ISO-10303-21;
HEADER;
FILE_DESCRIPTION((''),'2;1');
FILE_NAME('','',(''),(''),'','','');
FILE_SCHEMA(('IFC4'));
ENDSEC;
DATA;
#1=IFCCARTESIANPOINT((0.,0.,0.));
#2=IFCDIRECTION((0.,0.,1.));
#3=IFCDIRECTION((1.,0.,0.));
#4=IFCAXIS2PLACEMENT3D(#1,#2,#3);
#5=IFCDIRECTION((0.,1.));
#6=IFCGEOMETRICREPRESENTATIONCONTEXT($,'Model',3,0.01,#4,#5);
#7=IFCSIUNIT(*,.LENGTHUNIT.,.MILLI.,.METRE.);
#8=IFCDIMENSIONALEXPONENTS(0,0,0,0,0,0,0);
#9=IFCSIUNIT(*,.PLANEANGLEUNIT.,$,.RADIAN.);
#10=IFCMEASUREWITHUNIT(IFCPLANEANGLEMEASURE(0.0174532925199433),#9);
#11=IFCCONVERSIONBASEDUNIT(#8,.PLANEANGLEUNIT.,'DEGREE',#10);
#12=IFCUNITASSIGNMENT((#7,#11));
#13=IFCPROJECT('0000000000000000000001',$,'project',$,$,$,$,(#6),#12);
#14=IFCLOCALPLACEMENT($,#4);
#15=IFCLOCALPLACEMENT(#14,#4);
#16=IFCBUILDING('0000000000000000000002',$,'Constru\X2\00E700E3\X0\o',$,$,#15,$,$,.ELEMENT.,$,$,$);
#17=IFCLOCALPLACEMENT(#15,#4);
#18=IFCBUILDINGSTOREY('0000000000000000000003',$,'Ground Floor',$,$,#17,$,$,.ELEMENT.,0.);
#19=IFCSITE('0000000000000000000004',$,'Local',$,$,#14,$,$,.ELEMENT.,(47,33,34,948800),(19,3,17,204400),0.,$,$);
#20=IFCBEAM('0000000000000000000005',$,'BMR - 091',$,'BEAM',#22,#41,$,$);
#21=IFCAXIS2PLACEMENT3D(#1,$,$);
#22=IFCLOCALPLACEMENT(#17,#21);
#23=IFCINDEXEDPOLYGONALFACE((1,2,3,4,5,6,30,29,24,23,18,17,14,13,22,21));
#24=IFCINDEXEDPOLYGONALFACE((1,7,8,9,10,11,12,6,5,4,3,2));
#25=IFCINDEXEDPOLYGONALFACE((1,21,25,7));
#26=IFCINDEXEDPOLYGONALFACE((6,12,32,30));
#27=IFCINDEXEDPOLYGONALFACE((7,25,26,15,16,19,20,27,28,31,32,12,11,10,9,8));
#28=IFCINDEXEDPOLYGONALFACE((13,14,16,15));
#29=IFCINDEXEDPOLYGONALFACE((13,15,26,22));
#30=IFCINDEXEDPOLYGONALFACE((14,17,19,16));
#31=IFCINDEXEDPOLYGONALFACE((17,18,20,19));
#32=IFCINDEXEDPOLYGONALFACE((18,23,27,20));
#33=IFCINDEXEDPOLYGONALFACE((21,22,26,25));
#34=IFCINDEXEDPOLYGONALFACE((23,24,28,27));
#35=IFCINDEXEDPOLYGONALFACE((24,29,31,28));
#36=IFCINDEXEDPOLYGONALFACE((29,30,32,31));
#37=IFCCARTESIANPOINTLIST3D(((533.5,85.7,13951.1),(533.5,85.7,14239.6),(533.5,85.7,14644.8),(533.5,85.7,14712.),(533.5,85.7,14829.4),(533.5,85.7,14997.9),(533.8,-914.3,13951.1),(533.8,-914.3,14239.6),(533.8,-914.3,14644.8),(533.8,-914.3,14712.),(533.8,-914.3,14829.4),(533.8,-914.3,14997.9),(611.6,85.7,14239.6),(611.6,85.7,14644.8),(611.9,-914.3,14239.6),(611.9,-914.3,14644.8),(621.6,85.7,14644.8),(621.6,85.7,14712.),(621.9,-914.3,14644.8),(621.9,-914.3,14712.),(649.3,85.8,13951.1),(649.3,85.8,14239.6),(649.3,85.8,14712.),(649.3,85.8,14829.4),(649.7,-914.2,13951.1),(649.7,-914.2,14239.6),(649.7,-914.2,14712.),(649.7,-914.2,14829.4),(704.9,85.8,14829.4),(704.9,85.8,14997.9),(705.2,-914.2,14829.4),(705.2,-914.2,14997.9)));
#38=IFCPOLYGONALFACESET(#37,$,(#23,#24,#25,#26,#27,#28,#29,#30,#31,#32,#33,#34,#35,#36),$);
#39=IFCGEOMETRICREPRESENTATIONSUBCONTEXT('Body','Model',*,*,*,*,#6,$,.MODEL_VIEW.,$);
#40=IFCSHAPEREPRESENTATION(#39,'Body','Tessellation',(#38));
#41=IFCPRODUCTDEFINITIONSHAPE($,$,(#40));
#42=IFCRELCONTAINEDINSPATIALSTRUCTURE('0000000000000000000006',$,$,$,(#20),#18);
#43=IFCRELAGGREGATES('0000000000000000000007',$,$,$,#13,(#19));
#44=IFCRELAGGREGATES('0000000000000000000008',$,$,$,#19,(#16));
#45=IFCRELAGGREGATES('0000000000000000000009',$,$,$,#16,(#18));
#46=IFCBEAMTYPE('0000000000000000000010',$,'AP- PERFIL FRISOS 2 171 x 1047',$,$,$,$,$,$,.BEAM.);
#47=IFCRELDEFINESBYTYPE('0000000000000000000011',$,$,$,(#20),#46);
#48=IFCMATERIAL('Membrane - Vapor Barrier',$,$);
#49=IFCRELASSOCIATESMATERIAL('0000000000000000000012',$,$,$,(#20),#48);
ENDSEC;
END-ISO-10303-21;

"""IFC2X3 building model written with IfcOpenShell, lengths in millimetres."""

from ifc_helpers import new_model, entity, si_unit, converted_unit, direction, frame, origin_with_axes, place, context, subcontext, project, spatial, polyline, outline, extrude, material, type_object, element, save


model = new_model("IFC2X3")

# Units and contexts
model_context = context("Model", 3, precision=0.01, world=origin_with_axes(), true_north=direction((0.0, 1.0)))
body_context = subcontext(model_context, "Body", "Model", "MODEL_VIEW")
ifc_project = project(units=[si_unit("LENGTHUNIT", "METRE", prefix="MILLI"), converted_unit("PLANEANGLEUNIT", "DEGREE", entity("IfcPlaneAngleMeasure", 0.0174532925199433), si_unit("PLANEANGLEUNIT", "RADIAN"), dimensions=[0, 0, 0, 0, 0, 0, 0])], contexts=[model_context])

# Site, building, storey
site_placement = place(None, origin_with_axes())
site = spatial("IfcSite", under=ifc_project, at=site_placement, Name="Local", CompositionType="ELEMENT", RefLatitude=(47, 33, 34, 948800), RefLongitude=(19, 3, 17, 204400), RefElevation=0.0)
building_placement = place(site_placement, origin_with_axes())
building = spatial("IfcBuilding", under=site, at=building_placement, Name="Construção", CompositionType="ELEMENT")
storey_placement = place(building_placement, origin_with_axes())
storey = spatial("IfcBuildingStorey", under=building, at=storey_placement, Name="Ground Floor", CompositionType="ELEMENT", Elevation=0.0)

# Beam
ifc_material_1 = material(Name="Membrane - Vapor Barrier")
beam_type_1 = type_object("IfcBeamType", Name="AP- PERFIL FRISOS 2 171 x 1047", PredefinedType="BEAM")
beam_1_placement = place(storey_placement, frame((533.8, -914.3, 13951.1), z_axis=(0.0, 0.0, 1.0), x_axis=(1.0, 0.000322, 0.0)))
element("IfcBeam", 1, at=beam_1_placement, inside=storey, type_object=beam_type_1, material=ifc_material_1, Name="BMR - 091", ObjectType="BEAM", context=body_context, shape_type="SweptSolid", body=[
    extrude(outline(polyline([(0.0, 288.6), (0.0, 0.0), (115.9, 0.0), (115.9, 288.6), (78.1, 288.6), (78.1, 693.7), (88.1, 693.7), (88.1, 760.9), (115.9, 760.9), (115.9, 878.3), (171.4, 878.3), (171.4, 1046.8), (0.0, 1046.8), (0.0, 878.3), (0.0, 760.9), (0.0, 693.7), (0.0, 288.6)])), frame((0.0, 1000.0, 0.0), z_axis=(0.0, -1.0, 0.0), x_axis=(1.0, 0.0, 0.0)), (0.0, 0.0, 1.0), 1000.0),
])

save(model, "model.ifc")
